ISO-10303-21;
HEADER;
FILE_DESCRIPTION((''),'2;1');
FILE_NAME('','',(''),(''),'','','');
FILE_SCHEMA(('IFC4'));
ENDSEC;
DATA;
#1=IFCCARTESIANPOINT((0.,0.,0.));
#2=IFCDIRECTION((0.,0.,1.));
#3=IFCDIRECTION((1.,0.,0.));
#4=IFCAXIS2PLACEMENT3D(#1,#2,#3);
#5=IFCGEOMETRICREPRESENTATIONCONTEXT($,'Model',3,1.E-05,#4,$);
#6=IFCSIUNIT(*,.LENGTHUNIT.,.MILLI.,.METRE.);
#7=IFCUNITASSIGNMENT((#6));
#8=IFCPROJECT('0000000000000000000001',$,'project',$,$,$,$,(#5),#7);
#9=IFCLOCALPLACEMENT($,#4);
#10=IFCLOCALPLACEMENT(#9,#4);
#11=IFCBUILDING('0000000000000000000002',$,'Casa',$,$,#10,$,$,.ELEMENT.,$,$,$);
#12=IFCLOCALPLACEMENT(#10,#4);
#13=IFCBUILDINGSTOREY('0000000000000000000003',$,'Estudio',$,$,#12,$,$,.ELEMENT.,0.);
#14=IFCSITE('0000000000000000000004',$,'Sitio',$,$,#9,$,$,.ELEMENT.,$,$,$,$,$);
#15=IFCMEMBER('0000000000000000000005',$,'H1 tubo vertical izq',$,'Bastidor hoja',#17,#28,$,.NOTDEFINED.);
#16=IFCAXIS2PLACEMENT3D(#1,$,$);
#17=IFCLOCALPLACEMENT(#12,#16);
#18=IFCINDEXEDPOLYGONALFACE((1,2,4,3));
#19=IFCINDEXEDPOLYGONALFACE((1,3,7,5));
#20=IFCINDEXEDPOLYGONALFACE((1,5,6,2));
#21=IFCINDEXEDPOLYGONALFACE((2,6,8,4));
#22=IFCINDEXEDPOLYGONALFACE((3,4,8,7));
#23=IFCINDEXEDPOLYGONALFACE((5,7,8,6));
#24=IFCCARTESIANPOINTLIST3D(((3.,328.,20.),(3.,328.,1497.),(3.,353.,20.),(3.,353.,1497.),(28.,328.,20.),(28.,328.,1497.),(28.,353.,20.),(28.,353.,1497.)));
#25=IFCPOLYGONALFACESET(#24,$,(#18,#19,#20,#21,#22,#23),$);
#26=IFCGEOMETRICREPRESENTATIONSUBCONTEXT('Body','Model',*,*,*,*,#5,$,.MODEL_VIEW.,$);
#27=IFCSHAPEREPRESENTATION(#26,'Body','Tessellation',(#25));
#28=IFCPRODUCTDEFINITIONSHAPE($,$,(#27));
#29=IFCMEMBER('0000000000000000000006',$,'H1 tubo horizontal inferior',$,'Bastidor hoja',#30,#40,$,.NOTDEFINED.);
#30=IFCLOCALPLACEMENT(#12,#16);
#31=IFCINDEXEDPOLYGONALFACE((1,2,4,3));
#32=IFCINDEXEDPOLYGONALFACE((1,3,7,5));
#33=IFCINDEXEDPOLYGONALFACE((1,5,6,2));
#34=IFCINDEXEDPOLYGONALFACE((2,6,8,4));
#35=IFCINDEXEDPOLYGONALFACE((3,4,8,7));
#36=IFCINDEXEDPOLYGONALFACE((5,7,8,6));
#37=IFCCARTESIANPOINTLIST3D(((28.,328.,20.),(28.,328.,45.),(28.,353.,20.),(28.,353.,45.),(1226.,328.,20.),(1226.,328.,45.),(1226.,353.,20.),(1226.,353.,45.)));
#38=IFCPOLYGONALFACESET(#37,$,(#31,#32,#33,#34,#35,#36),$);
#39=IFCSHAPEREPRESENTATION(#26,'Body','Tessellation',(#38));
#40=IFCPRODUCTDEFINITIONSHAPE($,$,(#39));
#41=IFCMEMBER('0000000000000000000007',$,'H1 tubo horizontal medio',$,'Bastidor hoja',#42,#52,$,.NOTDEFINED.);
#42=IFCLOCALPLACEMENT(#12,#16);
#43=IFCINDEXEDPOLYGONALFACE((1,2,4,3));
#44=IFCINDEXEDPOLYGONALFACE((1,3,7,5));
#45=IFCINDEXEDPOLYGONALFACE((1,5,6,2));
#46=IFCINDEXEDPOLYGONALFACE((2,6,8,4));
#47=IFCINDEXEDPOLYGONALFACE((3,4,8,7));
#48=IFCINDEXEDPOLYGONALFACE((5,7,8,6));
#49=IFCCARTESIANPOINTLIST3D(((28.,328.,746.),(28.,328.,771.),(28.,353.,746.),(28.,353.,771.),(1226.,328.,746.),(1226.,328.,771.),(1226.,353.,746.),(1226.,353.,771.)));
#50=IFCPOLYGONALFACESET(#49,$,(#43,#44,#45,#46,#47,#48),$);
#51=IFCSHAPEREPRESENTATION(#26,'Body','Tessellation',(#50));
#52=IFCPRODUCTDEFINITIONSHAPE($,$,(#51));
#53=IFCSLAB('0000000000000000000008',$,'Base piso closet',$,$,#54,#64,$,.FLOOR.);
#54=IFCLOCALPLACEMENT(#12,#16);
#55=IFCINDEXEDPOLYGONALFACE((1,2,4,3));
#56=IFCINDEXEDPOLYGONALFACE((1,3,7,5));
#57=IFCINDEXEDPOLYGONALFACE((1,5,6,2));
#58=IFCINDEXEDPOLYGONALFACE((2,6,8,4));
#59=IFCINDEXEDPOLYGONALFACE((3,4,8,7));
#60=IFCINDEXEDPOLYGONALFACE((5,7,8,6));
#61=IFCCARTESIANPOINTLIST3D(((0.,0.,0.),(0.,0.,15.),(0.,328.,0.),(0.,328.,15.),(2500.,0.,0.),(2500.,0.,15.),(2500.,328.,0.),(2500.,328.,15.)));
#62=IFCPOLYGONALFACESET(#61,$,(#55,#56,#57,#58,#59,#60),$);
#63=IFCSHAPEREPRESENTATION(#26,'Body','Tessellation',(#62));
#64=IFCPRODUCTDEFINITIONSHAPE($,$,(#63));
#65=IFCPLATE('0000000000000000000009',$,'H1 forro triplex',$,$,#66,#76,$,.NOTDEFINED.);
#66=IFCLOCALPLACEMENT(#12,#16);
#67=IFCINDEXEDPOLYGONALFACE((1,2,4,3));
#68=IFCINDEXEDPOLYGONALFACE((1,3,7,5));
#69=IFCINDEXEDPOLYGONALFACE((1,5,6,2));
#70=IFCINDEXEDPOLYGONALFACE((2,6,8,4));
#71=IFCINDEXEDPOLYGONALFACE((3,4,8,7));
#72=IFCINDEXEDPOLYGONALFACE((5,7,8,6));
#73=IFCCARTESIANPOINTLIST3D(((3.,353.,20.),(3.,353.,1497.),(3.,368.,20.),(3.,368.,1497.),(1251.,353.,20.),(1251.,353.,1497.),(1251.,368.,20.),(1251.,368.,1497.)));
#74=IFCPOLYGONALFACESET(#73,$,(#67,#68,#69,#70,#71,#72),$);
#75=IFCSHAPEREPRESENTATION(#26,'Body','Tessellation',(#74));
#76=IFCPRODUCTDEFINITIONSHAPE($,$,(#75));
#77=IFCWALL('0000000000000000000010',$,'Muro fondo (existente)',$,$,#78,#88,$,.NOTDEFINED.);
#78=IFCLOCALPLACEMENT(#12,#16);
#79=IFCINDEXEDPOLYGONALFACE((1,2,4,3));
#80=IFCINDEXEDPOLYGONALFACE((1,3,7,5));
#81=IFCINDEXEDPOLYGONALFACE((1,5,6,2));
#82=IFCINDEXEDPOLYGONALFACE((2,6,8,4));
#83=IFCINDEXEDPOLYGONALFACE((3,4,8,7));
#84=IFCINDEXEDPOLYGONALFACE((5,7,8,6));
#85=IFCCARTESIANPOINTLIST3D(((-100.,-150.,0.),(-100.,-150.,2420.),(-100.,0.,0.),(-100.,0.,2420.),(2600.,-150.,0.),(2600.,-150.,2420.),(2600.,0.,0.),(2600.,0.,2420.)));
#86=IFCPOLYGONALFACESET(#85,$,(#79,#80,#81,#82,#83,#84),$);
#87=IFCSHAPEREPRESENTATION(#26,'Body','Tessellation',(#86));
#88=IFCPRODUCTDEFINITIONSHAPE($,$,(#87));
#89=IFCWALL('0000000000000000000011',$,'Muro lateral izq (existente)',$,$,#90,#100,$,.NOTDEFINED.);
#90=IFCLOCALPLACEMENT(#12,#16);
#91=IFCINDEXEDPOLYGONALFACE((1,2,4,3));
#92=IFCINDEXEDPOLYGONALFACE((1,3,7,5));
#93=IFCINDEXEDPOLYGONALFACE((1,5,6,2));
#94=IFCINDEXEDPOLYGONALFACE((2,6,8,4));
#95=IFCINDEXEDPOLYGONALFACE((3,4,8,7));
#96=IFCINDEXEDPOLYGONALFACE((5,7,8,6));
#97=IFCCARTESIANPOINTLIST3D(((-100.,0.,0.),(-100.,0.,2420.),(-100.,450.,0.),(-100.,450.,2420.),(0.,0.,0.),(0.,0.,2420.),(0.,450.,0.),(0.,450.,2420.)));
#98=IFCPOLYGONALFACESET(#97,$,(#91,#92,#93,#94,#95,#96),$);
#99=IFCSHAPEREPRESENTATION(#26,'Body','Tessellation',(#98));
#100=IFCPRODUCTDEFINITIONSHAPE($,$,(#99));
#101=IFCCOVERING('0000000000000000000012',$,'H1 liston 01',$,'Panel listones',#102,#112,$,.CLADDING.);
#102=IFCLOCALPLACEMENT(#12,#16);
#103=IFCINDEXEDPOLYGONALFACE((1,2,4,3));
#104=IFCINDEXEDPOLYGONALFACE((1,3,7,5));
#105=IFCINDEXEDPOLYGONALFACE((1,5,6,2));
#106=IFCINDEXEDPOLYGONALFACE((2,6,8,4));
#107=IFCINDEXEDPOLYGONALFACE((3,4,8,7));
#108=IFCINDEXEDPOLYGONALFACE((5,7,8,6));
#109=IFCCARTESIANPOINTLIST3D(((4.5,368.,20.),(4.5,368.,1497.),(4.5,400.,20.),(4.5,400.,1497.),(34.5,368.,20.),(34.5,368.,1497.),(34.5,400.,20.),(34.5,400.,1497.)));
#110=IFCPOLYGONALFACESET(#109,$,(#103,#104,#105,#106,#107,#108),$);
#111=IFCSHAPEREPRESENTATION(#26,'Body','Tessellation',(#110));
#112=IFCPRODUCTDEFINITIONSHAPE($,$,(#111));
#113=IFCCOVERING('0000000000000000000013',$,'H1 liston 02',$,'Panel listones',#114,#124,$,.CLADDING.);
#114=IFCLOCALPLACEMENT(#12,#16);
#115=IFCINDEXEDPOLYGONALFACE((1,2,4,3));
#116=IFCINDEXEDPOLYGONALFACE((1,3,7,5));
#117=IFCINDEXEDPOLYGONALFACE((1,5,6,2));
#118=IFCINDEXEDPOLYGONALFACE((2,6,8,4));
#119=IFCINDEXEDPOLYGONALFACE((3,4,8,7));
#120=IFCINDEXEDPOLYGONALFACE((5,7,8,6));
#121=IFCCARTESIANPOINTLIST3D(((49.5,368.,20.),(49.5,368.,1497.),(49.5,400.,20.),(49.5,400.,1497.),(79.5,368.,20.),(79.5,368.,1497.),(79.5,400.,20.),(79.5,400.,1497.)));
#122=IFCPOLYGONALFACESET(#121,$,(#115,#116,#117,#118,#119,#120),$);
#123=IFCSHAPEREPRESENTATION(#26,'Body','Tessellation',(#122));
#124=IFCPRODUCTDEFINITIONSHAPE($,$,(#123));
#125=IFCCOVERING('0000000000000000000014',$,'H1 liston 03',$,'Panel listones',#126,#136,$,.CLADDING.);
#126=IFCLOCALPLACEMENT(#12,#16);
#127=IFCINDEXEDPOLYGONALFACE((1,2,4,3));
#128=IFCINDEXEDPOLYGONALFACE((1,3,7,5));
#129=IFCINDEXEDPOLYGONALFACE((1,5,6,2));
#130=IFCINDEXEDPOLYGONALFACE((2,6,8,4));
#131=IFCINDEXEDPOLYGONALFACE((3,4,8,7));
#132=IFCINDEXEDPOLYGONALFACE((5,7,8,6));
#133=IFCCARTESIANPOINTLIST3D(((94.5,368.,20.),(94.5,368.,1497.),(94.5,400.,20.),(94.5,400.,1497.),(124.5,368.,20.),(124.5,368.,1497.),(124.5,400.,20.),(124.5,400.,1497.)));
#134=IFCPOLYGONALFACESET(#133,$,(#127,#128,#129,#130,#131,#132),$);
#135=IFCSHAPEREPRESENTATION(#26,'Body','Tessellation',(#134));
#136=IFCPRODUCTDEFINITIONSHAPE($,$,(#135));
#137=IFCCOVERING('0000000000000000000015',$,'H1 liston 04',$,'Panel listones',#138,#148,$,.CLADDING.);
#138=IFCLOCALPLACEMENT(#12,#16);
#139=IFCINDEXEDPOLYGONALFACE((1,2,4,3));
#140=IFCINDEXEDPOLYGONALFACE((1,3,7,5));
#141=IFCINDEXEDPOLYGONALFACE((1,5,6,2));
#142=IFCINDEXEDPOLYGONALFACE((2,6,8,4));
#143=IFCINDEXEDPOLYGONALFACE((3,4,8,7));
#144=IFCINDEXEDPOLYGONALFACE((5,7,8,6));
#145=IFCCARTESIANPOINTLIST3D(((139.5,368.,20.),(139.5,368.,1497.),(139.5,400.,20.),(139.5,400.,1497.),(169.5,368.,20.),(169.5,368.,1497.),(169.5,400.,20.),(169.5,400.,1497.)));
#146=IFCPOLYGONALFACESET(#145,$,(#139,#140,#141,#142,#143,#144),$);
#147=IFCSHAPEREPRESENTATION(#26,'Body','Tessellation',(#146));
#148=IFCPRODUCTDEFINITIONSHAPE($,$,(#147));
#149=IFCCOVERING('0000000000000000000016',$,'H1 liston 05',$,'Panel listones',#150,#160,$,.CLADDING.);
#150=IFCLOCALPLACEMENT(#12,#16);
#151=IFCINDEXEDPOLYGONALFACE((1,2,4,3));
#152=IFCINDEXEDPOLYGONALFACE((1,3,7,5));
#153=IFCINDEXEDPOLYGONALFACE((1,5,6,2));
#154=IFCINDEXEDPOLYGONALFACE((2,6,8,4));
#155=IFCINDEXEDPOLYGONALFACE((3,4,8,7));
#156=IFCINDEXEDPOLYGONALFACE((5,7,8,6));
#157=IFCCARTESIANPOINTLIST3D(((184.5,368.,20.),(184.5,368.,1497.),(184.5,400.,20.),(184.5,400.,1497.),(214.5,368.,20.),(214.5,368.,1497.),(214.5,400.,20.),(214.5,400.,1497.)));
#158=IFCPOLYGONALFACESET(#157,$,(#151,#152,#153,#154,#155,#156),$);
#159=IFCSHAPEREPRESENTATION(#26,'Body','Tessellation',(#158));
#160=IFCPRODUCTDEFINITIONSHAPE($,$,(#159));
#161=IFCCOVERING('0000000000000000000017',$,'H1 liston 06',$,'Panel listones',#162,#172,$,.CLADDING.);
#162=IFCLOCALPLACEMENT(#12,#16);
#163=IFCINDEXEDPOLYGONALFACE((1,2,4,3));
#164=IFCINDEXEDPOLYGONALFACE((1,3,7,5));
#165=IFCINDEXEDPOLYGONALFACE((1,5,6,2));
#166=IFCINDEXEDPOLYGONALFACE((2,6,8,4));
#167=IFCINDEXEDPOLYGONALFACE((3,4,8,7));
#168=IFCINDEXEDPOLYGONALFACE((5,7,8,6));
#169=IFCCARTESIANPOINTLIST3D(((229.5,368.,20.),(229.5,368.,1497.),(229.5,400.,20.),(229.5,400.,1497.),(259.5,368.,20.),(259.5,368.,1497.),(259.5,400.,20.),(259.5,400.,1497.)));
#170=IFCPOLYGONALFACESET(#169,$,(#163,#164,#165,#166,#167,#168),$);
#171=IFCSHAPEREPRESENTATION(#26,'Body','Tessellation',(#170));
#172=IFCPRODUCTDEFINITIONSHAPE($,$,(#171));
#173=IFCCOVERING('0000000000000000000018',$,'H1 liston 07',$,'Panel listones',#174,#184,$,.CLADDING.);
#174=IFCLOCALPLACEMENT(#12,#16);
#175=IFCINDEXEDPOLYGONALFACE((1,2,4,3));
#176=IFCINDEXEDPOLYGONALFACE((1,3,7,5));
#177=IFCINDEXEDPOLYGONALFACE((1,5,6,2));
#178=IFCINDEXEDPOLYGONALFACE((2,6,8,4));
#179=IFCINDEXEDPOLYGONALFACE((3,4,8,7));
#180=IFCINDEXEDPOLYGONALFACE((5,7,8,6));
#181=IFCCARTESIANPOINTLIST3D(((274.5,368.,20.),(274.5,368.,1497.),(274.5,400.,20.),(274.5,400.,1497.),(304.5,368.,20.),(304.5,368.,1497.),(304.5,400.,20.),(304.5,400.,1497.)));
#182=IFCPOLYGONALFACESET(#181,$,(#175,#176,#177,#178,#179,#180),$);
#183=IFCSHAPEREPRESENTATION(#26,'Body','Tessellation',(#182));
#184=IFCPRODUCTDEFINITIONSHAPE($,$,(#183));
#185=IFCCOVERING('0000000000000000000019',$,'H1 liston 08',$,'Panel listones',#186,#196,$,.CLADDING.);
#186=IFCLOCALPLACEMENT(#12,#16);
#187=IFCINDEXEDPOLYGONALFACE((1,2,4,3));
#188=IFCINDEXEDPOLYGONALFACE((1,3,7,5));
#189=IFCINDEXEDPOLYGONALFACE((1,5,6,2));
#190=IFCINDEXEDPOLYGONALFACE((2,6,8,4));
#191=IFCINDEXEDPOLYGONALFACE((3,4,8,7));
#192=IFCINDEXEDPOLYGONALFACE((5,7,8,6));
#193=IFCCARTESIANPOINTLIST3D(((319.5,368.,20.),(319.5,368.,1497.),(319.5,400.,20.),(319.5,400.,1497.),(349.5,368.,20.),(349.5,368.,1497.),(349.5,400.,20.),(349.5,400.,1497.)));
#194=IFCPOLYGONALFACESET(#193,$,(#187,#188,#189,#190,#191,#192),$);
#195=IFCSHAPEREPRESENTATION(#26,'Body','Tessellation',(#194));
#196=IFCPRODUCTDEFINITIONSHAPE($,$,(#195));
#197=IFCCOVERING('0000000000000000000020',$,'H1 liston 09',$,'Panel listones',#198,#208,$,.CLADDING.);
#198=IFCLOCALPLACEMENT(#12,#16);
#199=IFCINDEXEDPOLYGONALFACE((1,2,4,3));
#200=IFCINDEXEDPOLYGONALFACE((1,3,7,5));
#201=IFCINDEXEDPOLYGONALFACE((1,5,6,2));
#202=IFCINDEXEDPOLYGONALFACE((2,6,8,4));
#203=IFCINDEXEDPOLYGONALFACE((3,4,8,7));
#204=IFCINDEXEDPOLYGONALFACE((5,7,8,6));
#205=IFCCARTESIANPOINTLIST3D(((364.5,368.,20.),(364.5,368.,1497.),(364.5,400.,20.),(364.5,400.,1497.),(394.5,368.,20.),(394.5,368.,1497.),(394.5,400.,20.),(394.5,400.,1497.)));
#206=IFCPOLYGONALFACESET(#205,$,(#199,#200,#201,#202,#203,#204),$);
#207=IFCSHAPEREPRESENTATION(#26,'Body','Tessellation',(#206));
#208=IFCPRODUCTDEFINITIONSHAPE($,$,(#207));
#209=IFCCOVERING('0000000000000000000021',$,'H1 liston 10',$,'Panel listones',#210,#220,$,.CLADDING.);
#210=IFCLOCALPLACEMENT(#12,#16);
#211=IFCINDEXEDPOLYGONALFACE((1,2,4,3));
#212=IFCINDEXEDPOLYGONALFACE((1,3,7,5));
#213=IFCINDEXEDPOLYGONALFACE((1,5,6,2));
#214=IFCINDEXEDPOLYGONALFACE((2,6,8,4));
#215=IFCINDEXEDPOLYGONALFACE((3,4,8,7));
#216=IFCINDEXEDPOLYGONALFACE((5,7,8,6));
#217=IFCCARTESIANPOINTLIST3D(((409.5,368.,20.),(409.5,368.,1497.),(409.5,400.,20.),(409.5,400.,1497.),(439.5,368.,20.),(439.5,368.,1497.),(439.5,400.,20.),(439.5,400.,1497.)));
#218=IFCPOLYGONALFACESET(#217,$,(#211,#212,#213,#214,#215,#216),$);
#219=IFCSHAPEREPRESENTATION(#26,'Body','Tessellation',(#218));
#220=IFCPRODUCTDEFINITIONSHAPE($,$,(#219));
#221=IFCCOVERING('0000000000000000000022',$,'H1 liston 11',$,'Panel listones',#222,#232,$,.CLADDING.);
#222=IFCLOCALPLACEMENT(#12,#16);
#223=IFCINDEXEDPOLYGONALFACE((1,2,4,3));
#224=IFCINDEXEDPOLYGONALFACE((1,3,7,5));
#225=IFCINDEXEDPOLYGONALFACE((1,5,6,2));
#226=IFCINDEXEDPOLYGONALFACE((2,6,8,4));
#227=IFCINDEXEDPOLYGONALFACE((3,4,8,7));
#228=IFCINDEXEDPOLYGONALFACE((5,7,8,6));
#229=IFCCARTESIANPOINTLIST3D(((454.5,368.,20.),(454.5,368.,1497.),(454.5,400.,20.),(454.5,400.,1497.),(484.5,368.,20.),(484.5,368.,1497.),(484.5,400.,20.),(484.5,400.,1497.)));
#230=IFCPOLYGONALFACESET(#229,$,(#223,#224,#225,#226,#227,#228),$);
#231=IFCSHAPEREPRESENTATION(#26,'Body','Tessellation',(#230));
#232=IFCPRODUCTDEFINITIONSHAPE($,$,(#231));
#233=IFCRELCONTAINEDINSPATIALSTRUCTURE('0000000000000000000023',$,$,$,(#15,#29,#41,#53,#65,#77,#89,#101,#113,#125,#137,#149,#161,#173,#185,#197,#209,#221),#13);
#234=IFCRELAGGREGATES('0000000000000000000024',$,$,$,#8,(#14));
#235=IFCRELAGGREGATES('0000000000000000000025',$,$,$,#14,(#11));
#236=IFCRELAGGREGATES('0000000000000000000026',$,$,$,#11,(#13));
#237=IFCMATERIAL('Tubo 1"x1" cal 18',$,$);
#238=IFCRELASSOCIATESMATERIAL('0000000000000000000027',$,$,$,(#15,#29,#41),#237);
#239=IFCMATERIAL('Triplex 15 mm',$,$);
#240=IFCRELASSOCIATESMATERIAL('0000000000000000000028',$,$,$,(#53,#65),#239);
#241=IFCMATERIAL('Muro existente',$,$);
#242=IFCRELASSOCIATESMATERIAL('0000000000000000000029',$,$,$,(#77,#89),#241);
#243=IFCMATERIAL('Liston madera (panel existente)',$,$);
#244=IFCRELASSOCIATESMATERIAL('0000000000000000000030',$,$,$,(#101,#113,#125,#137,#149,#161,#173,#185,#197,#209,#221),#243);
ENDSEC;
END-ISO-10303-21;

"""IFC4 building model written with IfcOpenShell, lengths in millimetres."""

from ifc_helpers import new_model, si_unit, frame, frame_2d, origin_with_axes, place, context, subcontext, project, spatial, rectangle, extrude, material, element, save


model = new_model("IFC4")

# Units and contexts
model_context = context("Model", 3, precision=1e-05, world=origin_with_axes())
body_context = subcontext(model_context, "Body", "Model", "MODEL_VIEW")
ifc_project = project(units=[si_unit("LENGTHUNIT", "METRE", prefix="MILLI")], contexts=[model_context])

# Site, building, storey
site_placement = place(None, origin_with_axes())
site = spatial("IfcSite", under=ifc_project, at=site_placement, Name="Sitio", CompositionType="ELEMENT")
building_placement = place(site_placement, origin_with_axes())
building = spatial("IfcBuilding", under=site, at=building_placement, Name="Casa", CompositionType="ELEMENT")
storey_placement = place(building_placement, origin_with_axes())
storey = spatial("IfcBuildingStorey", under=building, at=storey_placement, Name="Estudio", CompositionType="ELEMENT", Elevation=0.0)

# Members
ifc_material_1 = material(Name="Tubo 1\"x1\" cal 18")
member_placement = place(storey_placement, frame((3.0, 328.0, 20.0), z_axis=(0.0, 0.0, 1.0), x_axis=(1.0, 0.0, 0.0)))
element("IfcMember", 1, at=member_placement, inside=storey, material=ifc_material_1, Name="H1 tubo vertical izq", ObjectType="Bastidor hoja", PredefinedType="NOTDEFINED", context=body_context, shape_type="SweptSolid", body=[
    extrude(rectangle(XDim=25.0, YDim=25.0, at=frame_2d((12.5, 12.5))), origin_with_axes(), (0.0, 0.0, 1.0), 1477.0),
])
for number, where, z_axis, x_axis, name in (
    (2, (28.0, 328.0, 20.0), (0.0, 0.0, 1.0), (1.0, 0.0, 0.0), "H1 tubo horizontal inferior"),
    (3, (28.0, 328.0, 746.0), (0.0, 0.0, 1.0), (1.0, 0.0, 0.0), "H1 tubo horizontal medio"),
):
    element("IfcMember", number, at=place(storey_placement, frame(where, z_axis=z_axis, x_axis=x_axis)), inside=storey, material=ifc_material_1, Name=name, ObjectType="Bastidor hoja", PredefinedType="NOTDEFINED", context=body_context, shape_type="SweptSolid", body=[
        extrude(rectangle(XDim=1198.0, YDim=25.0, at=frame_2d((599.0, 12.5))), origin_with_axes(), (0.0, 0.0, 1.0), 25.0),
    ])

# Slab
ifc_material_2 = material(Name="Triplex 15 mm")
slab_placement = place(storey_placement, origin_with_axes())
element("IfcSlab", 4, at=slab_placement, inside=storey, material=ifc_material_2, Name="Base piso closet", PredefinedType="FLOOR", context=body_context, shape_type="SweptSolid", body=[
    extrude(rectangle(XDim=2500.0, YDim=328.0, at=frame_2d((1250.0, 164.0))), origin_with_axes(), (0.0, 0.0, 1.0), 15.0),
])

# Plate
plate_placement = place(storey_placement, frame((3.0, 353.0, 20.0), z_axis=(0.0, 0.0, 1.0), x_axis=(1.0, 0.0, 0.0)))
element("IfcPlate", 5, at=plate_placement, inside=storey, material=ifc_material_2, Name="H1 forro triplex", PredefinedType="NOTDEFINED", context=body_context, shape_type="SweptSolid", body=[
    extrude(rectangle(XDim=1248.0, YDim=15.0, at=frame_2d((624.0, 7.5))), origin_with_axes(), (0.0, 0.0, 1.0), 1477.0),
])

# Walls
ifc_material_3 = material(Name="Muro existente")
wall_1_placement = place(storey_placement, frame((-100.0, -150.0, 0.0), z_axis=(0.0, 0.0, 1.0), x_axis=(1.0, 0.0, 0.0)))
element("IfcWall", 6, at=wall_1_placement, inside=storey, material=ifc_material_3, Name="Muro fondo (existente)", PredefinedType="NOTDEFINED", context=body_context, shape_type="SweptSolid", body=[
    extrude(rectangle(XDim=2700.0, YDim=150.0, at=frame_2d((1350.0, 75.0))), origin_with_axes(), (0.0, 0.0, 1.0), 2420.0),
])
wall_2_placement = place(storey_placement, frame((-100.0, 0.0, 0.0), z_axis=(0.0, 0.0, 1.0), x_axis=(1.0, 0.0, 0.0)))
element("IfcWall", 7, at=wall_2_placement, inside=storey, material=ifc_material_3, Name="Muro lateral izq (existente)", PredefinedType="NOTDEFINED", context=body_context, shape_type="SweptSolid", body=[
    extrude(rectangle(XDim=100.0, YDim=450.0, at=frame_2d((50.0, 225.0))), origin_with_axes(), (0.0, 0.0, 1.0), 2420.0),
])

# Coverings
ifc_material_4 = material(Name="Liston madera (panel existente)")
for number, where, z_axis, x_axis, name in (
    (8, (4.5, 368.0, 20.0), (0.0, 0.0, 1.0), (1.0, 0.0, 0.0), "H1 liston 01"),
    (9, (49.5, 368.0, 20.0), (0.0, 0.0, 1.0), (1.0, 0.0, 0.0), "H1 liston 02"),
    (10, (94.5, 368.0, 20.0), (0.0, 0.0, 1.0), (1.0, 0.0, 0.0), "H1 liston 03"),
    (11, (139.5, 368.0, 20.0), (0.0, 0.0, 1.0), (1.0, 0.0, 0.0), "H1 liston 04"),
    (12, (184.5, 368.0, 20.0), (0.0, 0.0, 1.0), (1.0, 0.0, 0.0), "H1 liston 05"),
    (13, (229.5, 368.0, 20.0), (0.0, 0.0, 1.0), (1.0, 0.0, 0.0), "H1 liston 06"),
    (14, (274.5, 368.0, 20.0), (0.0, 0.0, 1.0), (1.0, 0.0, 0.0), "H1 liston 07"),
    (15, (319.5, 368.0, 20.0), (0.0, 0.0, 1.0), (1.0, 0.0, 0.0), "H1 liston 08"),
    (16, (364.5, 368.0, 20.0), (0.0, 0.0, 1.0), (1.0, 0.0, 0.0), "H1 liston 09"),
    (17, (409.5, 368.0, 20.0), (0.0, 0.0, 1.0), (1.0, 0.0, 0.0), "H1 liston 10"),
    (18, (454.5, 368.0, 20.0), (0.0, 0.0, 1.0), (1.0, 0.0, 0.0), "H1 liston 11"),
):
    element("IfcCovering", number, at=place(storey_placement, frame(where, z_axis=z_axis, x_axis=x_axis)), inside=storey, material=ifc_material_4, Name=name, ObjectType="Panel listones", PredefinedType="CLADDING", context=body_context, shape_type="SweptSolid", body=[
        extrude(rectangle(XDim=30.0, YDim=32.0, at=frame_2d((15.0, 16.0))), origin_with_axes(), (0.0, 0.0, 1.0), 1477.0),
    ])

save(model, "model.ifc")
